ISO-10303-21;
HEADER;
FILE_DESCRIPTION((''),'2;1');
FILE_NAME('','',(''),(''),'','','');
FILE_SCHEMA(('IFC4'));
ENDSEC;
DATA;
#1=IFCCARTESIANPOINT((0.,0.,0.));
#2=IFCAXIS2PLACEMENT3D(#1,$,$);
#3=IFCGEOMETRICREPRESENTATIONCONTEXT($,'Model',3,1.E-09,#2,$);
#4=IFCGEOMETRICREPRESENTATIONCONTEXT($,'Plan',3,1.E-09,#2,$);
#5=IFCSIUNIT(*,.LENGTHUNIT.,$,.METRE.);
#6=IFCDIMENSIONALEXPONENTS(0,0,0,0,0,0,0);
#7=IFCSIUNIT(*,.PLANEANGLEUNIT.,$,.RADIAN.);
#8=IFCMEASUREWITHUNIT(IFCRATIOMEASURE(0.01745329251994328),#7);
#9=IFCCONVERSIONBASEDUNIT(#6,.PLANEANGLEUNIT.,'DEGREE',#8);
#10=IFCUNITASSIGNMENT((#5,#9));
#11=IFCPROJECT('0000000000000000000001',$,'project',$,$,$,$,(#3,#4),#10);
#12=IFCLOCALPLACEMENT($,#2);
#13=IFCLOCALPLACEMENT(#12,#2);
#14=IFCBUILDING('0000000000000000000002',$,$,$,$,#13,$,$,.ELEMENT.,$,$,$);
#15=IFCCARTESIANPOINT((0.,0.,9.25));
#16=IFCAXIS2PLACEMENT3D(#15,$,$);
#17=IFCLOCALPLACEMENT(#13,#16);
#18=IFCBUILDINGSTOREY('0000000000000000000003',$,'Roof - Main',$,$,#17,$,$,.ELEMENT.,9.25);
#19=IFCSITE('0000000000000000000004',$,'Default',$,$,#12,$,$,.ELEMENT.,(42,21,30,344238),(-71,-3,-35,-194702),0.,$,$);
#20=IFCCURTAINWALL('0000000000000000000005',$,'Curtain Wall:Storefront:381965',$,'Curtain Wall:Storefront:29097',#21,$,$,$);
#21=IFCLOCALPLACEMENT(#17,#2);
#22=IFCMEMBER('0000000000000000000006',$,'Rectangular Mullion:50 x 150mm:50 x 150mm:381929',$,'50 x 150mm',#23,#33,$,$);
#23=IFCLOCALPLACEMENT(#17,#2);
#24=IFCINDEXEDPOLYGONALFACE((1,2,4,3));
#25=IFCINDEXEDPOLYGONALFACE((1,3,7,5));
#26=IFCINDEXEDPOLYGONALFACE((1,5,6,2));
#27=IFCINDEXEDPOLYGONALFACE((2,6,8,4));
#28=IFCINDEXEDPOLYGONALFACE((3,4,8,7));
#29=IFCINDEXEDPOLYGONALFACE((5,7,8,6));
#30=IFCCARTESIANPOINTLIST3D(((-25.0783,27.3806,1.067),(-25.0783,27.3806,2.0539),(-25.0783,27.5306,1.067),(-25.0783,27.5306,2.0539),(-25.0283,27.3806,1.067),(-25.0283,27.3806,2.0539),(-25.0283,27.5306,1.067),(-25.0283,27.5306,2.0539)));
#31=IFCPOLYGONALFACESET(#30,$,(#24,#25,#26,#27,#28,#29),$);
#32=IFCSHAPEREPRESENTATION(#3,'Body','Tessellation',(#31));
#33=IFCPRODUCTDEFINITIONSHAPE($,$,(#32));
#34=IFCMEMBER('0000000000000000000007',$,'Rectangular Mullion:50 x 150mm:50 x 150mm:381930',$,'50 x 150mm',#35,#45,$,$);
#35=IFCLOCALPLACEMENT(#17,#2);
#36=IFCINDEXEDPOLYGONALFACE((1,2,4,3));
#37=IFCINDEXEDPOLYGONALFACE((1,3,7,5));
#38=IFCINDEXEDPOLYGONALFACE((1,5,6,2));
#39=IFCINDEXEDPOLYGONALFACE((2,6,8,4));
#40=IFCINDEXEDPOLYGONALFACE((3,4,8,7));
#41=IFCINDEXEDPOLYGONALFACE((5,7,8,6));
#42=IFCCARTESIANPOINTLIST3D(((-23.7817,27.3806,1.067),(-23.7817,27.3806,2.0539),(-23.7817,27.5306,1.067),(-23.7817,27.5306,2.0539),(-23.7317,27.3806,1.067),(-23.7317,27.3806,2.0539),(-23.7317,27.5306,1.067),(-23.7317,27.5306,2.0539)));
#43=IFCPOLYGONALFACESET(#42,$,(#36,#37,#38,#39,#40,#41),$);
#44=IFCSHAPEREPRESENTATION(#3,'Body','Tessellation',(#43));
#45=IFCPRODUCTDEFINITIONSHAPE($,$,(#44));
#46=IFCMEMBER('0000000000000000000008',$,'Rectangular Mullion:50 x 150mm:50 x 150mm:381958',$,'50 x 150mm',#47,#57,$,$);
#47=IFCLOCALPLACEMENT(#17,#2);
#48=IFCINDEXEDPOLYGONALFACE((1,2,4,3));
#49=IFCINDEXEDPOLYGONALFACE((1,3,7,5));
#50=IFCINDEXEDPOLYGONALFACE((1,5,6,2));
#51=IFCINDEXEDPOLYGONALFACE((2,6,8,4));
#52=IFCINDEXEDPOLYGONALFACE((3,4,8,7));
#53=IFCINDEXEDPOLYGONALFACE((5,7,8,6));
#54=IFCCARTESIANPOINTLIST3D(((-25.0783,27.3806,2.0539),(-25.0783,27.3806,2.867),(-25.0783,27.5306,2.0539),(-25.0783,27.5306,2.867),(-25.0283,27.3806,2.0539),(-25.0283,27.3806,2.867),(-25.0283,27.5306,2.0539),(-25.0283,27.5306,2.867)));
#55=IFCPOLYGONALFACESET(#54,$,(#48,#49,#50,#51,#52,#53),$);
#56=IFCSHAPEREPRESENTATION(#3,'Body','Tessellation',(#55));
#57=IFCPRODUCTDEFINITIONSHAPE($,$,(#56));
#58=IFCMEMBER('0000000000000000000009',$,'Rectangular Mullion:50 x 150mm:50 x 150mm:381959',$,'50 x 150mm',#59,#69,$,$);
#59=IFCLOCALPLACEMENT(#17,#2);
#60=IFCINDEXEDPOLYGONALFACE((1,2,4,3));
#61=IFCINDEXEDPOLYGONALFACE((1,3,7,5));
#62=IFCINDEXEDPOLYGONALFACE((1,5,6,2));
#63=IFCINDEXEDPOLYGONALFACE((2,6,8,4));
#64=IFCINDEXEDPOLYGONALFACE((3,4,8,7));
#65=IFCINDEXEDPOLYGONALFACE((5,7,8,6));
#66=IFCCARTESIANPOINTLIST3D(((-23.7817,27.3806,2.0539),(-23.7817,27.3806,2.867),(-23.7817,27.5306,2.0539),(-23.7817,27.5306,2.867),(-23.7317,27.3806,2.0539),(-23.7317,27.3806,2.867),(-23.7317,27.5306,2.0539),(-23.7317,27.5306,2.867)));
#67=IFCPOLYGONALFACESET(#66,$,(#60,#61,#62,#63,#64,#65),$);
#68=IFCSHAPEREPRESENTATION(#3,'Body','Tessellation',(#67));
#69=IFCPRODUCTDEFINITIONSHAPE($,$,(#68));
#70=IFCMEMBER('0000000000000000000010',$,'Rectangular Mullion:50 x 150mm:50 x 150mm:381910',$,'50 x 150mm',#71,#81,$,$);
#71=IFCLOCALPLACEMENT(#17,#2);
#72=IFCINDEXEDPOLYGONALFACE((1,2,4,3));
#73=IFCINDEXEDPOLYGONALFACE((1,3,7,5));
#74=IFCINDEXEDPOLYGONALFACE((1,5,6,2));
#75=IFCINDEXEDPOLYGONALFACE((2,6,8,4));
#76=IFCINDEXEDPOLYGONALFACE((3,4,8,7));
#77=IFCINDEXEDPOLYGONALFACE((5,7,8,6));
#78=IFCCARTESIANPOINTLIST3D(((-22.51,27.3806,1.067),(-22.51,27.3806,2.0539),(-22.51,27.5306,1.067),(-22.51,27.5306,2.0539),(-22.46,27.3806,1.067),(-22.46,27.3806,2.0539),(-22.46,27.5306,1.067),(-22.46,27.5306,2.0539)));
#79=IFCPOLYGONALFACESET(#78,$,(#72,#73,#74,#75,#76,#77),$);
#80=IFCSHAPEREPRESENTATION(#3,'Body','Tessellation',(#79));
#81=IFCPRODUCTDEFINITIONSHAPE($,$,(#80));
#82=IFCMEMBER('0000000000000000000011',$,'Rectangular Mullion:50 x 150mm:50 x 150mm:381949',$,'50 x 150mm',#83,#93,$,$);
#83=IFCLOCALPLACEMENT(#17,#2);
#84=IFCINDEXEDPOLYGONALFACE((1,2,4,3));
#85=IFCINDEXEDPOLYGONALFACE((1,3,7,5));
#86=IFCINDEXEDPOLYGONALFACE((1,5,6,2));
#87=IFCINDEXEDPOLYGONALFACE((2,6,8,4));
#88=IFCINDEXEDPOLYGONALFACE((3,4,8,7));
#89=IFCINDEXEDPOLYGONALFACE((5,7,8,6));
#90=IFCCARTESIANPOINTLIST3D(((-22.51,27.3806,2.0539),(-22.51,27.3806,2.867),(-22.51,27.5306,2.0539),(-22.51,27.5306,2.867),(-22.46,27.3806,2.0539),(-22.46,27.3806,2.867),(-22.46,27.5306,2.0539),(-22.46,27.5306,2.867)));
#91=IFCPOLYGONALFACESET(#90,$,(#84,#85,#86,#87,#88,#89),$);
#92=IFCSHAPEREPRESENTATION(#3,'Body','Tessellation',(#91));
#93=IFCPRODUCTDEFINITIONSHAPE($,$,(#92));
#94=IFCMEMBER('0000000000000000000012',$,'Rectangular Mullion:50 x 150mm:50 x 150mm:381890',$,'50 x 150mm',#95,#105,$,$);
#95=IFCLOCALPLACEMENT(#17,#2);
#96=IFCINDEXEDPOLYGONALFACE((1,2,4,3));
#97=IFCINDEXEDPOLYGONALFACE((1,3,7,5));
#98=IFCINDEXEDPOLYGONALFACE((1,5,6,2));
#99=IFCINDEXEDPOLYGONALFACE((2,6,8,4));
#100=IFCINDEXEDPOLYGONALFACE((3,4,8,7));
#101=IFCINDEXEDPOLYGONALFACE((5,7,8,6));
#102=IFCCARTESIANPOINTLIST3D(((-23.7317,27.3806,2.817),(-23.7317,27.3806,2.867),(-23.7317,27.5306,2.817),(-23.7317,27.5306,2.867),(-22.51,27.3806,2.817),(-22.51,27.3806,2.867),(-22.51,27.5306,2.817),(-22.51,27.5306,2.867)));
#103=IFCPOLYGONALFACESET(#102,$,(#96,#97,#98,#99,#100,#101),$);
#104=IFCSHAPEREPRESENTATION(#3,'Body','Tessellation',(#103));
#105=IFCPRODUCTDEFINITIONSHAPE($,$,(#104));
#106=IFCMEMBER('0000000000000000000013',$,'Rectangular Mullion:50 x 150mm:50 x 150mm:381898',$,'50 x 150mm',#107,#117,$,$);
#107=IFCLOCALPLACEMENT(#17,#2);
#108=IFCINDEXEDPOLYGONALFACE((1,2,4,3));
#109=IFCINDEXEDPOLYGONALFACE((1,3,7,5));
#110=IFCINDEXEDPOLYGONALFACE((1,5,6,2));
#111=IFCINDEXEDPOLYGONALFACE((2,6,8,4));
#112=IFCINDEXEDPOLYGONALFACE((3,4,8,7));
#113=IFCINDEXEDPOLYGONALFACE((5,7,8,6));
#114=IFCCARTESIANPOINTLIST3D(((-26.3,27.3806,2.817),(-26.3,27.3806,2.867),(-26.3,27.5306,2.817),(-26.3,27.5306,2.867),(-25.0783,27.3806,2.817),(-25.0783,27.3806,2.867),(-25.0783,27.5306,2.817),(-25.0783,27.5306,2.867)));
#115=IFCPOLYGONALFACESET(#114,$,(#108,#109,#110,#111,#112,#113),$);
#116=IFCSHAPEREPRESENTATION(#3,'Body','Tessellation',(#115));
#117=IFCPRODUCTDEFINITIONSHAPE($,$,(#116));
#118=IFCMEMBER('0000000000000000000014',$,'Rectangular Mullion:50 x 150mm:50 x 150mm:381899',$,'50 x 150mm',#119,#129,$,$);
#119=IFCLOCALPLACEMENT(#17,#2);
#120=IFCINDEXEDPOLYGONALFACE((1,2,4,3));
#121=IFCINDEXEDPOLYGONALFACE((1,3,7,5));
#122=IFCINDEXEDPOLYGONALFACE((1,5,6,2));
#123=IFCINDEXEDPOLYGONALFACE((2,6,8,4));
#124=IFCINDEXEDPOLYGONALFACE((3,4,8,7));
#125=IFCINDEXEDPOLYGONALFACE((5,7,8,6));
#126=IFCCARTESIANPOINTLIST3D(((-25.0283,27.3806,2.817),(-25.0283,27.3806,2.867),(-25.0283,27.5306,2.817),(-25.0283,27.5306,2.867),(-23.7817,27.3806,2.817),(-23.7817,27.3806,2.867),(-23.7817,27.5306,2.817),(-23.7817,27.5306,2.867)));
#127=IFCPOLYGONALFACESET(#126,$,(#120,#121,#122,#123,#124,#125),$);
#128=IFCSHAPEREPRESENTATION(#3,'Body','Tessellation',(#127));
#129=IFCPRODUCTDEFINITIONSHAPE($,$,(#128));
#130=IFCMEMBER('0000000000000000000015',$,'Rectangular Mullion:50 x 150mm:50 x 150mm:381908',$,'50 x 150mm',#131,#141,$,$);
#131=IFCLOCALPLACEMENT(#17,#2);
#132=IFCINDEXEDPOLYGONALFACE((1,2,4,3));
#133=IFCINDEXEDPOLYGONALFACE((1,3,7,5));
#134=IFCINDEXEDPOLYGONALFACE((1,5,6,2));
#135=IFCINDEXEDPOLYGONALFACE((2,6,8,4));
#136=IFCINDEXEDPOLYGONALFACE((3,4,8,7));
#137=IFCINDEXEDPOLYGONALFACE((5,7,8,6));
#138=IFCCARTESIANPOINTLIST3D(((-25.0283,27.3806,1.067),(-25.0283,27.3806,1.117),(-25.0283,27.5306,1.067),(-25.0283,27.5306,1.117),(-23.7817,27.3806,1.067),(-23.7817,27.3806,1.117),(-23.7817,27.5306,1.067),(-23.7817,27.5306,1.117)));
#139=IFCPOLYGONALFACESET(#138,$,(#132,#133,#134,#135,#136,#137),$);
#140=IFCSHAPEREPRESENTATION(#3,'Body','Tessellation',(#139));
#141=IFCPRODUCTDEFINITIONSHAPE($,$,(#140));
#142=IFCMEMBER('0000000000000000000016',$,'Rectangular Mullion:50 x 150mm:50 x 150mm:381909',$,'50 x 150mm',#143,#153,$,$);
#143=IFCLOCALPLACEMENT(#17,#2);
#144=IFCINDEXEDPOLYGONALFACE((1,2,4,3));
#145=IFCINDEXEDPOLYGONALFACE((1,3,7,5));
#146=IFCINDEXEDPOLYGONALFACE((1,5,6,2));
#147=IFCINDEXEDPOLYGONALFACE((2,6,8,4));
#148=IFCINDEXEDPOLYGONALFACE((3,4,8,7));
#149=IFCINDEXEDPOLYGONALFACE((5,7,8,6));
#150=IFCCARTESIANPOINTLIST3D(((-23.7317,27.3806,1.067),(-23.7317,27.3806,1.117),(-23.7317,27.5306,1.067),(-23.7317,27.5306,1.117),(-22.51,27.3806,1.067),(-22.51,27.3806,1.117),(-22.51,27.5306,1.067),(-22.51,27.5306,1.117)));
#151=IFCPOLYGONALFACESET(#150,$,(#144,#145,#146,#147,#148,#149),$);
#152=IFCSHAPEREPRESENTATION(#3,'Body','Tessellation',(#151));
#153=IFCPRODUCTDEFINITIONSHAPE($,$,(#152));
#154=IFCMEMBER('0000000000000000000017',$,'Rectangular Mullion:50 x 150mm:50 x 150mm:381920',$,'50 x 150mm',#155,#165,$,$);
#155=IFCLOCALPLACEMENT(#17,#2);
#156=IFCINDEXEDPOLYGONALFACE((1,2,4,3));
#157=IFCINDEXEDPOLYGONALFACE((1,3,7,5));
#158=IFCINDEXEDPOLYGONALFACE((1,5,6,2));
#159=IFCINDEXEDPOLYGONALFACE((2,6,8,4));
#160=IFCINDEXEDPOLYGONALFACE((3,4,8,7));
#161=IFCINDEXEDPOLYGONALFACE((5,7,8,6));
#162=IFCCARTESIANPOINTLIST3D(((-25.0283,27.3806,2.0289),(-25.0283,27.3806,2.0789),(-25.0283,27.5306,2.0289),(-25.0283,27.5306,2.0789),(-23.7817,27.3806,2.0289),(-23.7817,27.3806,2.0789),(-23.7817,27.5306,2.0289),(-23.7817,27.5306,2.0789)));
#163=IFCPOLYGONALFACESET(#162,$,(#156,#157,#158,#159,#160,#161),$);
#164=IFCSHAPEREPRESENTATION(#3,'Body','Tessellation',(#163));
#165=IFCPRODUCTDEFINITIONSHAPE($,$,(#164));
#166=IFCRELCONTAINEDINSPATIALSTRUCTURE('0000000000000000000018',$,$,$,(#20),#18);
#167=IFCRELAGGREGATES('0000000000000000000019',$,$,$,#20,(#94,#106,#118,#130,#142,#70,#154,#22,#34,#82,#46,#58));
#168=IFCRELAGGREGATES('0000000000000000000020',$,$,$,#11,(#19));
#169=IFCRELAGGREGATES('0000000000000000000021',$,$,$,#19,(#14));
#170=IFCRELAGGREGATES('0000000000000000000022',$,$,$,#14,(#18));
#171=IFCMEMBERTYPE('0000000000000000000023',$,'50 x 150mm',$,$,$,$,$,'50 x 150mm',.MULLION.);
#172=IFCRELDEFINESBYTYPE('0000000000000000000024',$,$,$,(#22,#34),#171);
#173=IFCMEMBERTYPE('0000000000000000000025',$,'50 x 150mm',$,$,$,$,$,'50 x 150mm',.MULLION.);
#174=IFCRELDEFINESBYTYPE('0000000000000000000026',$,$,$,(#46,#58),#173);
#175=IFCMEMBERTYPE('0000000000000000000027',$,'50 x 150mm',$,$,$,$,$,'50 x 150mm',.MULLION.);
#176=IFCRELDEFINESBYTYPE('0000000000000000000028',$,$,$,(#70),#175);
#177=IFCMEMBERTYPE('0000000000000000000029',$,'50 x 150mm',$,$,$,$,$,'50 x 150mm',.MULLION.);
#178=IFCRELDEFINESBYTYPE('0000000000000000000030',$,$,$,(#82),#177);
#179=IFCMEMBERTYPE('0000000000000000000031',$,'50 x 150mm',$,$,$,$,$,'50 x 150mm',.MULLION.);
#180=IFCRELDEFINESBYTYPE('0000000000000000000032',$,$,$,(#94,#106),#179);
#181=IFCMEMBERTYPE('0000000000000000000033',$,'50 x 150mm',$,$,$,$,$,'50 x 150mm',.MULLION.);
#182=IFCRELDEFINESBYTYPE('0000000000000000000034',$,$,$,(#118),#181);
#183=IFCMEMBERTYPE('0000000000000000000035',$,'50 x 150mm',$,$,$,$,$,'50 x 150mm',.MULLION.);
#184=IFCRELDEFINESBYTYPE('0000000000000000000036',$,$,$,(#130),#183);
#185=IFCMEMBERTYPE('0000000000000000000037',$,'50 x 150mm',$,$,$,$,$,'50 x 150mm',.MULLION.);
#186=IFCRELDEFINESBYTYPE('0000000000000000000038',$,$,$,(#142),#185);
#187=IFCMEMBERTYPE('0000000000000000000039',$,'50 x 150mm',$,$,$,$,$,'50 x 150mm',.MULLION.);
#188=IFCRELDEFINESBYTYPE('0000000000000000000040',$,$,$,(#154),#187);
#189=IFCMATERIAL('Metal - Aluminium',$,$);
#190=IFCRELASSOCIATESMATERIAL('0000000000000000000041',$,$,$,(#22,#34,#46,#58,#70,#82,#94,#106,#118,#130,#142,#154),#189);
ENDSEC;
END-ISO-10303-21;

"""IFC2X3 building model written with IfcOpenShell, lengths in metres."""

from ifc_helpers import new_model, entity, si_unit, converted_unit, frame, origin, origin_2d_with_axis, place, context, project, spatial, rectangle, extrude, source, transform, mapped, material, type_object, type_shapes, element, aggregate, save


model = new_model("IFC2X3")

# Units and contexts
model_context = context("Model", 3, precision=1e-09, world=origin())
plan_context = context("Plan", 3, precision=1e-09, world=origin())
ifc_project = project(units=[si_unit("LENGTHUNIT", "METRE"), converted_unit("PLANEANGLEUNIT", "DEGREE", entity("IfcRatioMeasure", 0.01745329251994328), si_unit("PLANEANGLEUNIT", "RADIAN"), dimensions=[0, 0, 0, 0, 0, 0, 0])], contexts=[model_context, plan_context])

# Site, building, storey
site_placement = place(None, origin())
site = spatial("IfcSite", under=ifc_project, at=site_placement, Name="Default", CompositionType="ELEMENT", RefLatitude=(42, 21, 30, 344238), RefLongitude=(-71, -3, -35, -194702), RefElevation=0.0)
building_placement = place(site_placement, origin())
building = spatial("IfcBuilding", under=site, at=building_placement, CompositionType="ELEMENT")
storey_placement = place(building_placement, frame((0.0, 0.0, 9.25)))
storey = spatial("IfcBuildingStorey", under=building, at=storey_placement, Name="Roof - Main", CompositionType="ELEMENT", Elevation=9.25)

# Shared definitions
ifc_material_1 = material(Name="Metal - Aluminium")

# Curtain wall, members
curtain_wall_1_placement = place(storey_placement, origin())
curtain_wall_1 = element("IfcCurtainWall", 1, at=curtain_wall_1_placement, inside=storey, Name="Curtain Wall:Storefront:381965", ObjectType="Curtain Wall:Storefront:29097")
member_type_1 = type_object("IfcMemberType", Name="50 x 150mm", ElementType="50 x 150mm", PredefinedType="MULLION")
shared_shape_1 = source(origin(), model_context, "Body", "SweptSolid", [
    extrude(rectangle(XDim=0.05, YDim=0.15, at=origin_2d_with_axis()), frame((0.0, 0.0, -0.9869), z_axis=(0.0, 0.0, 1.0), x_axis=(-1.0, 0.0, 0.0)), (0.0, 0.0, 1.0), 0.9869),
])
type_shapes(member_type_1, [shared_shape_1])
member_1_placement = place(storey_placement, frame((-25.0533, 27.4556, 1.067), z_axis=(0.0, 0.0, -1.0), x_axis=(1.0, 0.0, 0.0)))
member_1 = element("IfcMember", 2, at=member_1_placement, type_object=member_type_1, material=ifc_material_1, Name="Rectangular Mullion:50 x 150mm:50 x 150mm:381929", ObjectType="50 x 150mm", context=model_context, shape_type="MappedRepresentation", body=[
    mapped(shared_shape_1, transform((0.0, 0.0, 0.0), scale=1.0)),
])
member_2_placement = place(storey_placement, frame((-23.7567, 27.4556, 1.067), z_axis=(0.0, 0.0, -1.0), x_axis=(1.0, 0.0, 0.0)))
member_2 = element("IfcMember", 3, at=member_2_placement, type_object=member_type_1, material=ifc_material_1, Name="Rectangular Mullion:50 x 150mm:50 x 150mm:381930", ObjectType="50 x 150mm", context=model_context, shape_type="MappedRepresentation", body=[
    mapped(shared_shape_1, transform((0.0, 0.0, 0.0), scale=1.0)),
])
member_type_2 = type_object("IfcMemberType", Name="50 x 150mm", ElementType="50 x 150mm", PredefinedType="MULLION")
shared_shape_2 = source(origin(), model_context, "Body", "SweptSolid", [
    extrude(rectangle(XDim=0.05, YDim=0.15, at=origin_2d_with_axis()), frame((0.0, 0.0, -0.8131), z_axis=(0.0, 0.0, 1.0), x_axis=(-1.0, 0.0, 0.0)), (0.0, 0.0, 1.0), 0.8131),
])
type_shapes(member_type_2, [shared_shape_2])
member_3_placement = place(storey_placement, frame((-25.0533, 27.4556, 2.0539), z_axis=(0.0, 0.0, -1.0), x_axis=(1.0, 0.0, 0.0)))
member_3 = element("IfcMember", 4, at=member_3_placement, type_object=member_type_2, material=ifc_material_1, Name="Rectangular Mullion:50 x 150mm:50 x 150mm:381958", ObjectType="50 x 150mm", context=model_context, shape_type="MappedRepresentation", body=[
    mapped(shared_shape_2, transform((0.0, 0.0, 0.0), scale=1.0)),
])
member_4_placement = place(storey_placement, frame((-23.7567, 27.4556, 2.0539), z_axis=(0.0, 0.0, -1.0), x_axis=(1.0, 0.0, 0.0)))
member_4 = element("IfcMember", 5, at=member_4_placement, type_object=member_type_2, material=ifc_material_1, Name="Rectangular Mullion:50 x 150mm:50 x 150mm:381959", ObjectType="50 x 150mm", context=model_context, shape_type="MappedRepresentation", body=[
    mapped(shared_shape_2, transform((0.0, 0.0, 0.0), scale=1.0)),
])
member_type_3 = type_object("IfcMemberType", Name="50 x 150mm", ElementType="50 x 150mm", PredefinedType="MULLION")
shared_shape_3 = source(origin(), model_context, "Body", "SweptSolid", [
    extrude(rectangle(XDim=0.05, YDim=0.15, at=origin_2d_with_axis()), frame((-0.025, 0.0, -0.9869), z_axis=(0.0, 0.0, 1.0), x_axis=(-1.0, 0.0, 0.0)), (0.0, 0.0, 1.0), 0.9869),
])
type_shapes(member_type_3, [shared_shape_3])
member_5_placement = place(storey_placement, frame((-22.46, 27.4556, 1.067), z_axis=(0.0, 0.0, -1.0), x_axis=(1.0, 0.0, 0.0)))
member_5 = element("IfcMember", 6, at=member_5_placement, type_object=member_type_3, material=ifc_material_1, Name="Rectangular Mullion:50 x 150mm:50 x 150mm:381910", ObjectType="50 x 150mm", context=model_context, shape_type="MappedRepresentation", body=[
    mapped(shared_shape_3, transform((0.0, 0.0, 0.0), scale=1.0)),
])
member_type_4 = type_object("IfcMemberType", Name="50 x 150mm", ElementType="50 x 150mm", PredefinedType="MULLION")
shared_shape_4 = source(origin(), model_context, "Body", "SweptSolid", [
    extrude(rectangle(XDim=0.05, YDim=0.15, at=origin_2d_with_axis()), frame((-0.025, 0.0, -0.8131), z_axis=(0.0, 0.0, 1.0), x_axis=(-1.0, 0.0, 0.0)), (0.0, 0.0, 1.0), 0.8131),
])
type_shapes(member_type_4, [shared_shape_4])
member_6_placement = place(storey_placement, frame((-22.46, 27.4556, 2.0539), z_axis=(0.0, 0.0, -1.0), x_axis=(1.0, 0.0, 0.0)))
member_6 = element("IfcMember", 7, at=member_6_placement, type_object=member_type_4, material=ifc_material_1, Name="Rectangular Mullion:50 x 150mm:50 x 150mm:381949", ObjectType="50 x 150mm", context=model_context, shape_type="MappedRepresentation", body=[
    mapped(shared_shape_4, transform((0.0, 0.0, 0.0), scale=1.0)),
])
member_type_5 = type_object("IfcMemberType", Name="50 x 150mm", ElementType="50 x 150mm", PredefinedType="MULLION")
shared_shape_5 = source(origin(), model_context, "Body", "SweptSolid", [
    extrude(rectangle(XDim=0.05, YDim=0.15, at=origin_2d_with_axis()), frame((-0.025, 0.0, -1.2217), z_axis=(0.0, 0.0, 1.0), x_axis=(-1.0, 0.0, 0.0)), (0.0, 0.0, 1.0), 1.2217),
])
type_shapes(member_type_5, [shared_shape_5])
member_7_placement = place(storey_placement, frame((-22.51, 27.4556, 2.867), z_axis=(1.0, 0.0, 0.0), x_axis=(0.0, 0.0, 1.0)))
member_7 = element("IfcMember", 8, at=member_7_placement, type_object=member_type_5, material=ifc_material_1, Name="Rectangular Mullion:50 x 150mm:50 x 150mm:381890", ObjectType="50 x 150mm", context=model_context, shape_type="MappedRepresentation", body=[
    mapped(shared_shape_5, transform((0.0, 0.0, 0.0), scale=1.0)),
])
member_8_placement = place(storey_placement, frame((-25.0783, 27.4556, 2.867), z_axis=(1.0, 0.0, 0.0), x_axis=(0.0, 0.0, 1.0)))
member_8 = element("IfcMember", 9, at=member_8_placement, type_object=member_type_5, material=ifc_material_1, Name="Rectangular Mullion:50 x 150mm:50 x 150mm:381898", ObjectType="50 x 150mm", context=model_context, shape_type="MappedRepresentation", body=[
    mapped(shared_shape_5, transform((0.0, 0.0, 0.0), scale=1.0)),
])
member_type_6 = type_object("IfcMemberType", Name="50 x 150mm", ElementType="50 x 150mm", PredefinedType="MULLION")
shared_shape_6 = source(origin(), model_context, "Body", "SweptSolid", [
    extrude(rectangle(XDim=0.05, YDim=0.15, at=origin_2d_with_axis()), frame((-0.025, 0.0, -1.2467), z_axis=(0.0, 0.0, 1.0), x_axis=(-1.0, 0.0, 0.0)), (0.0, 0.0, 1.0), 1.2467),
])
type_shapes(member_type_6, [shared_shape_6])
member_9_placement = place(storey_placement, frame((-23.7817, 27.4556, 2.867), z_axis=(1.0, 0.0, 0.0), x_axis=(0.0, 0.0, 1.0)))
member_9 = element("IfcMember", 10, at=member_9_placement, type_object=member_type_6, material=ifc_material_1, Name="Rectangular Mullion:50 x 150mm:50 x 150mm:381899", ObjectType="50 x 150mm", context=model_context, shape_type="MappedRepresentation", body=[
    mapped(shared_shape_6, transform((0.0, 0.0, 0.0), scale=1.0)),
])
member_type_7 = type_object("IfcMemberType", Name="50 x 150mm", ElementType="50 x 150mm", PredefinedType="MULLION")
shared_shape_7 = source(origin(), model_context, "Body", "SweptSolid", [
    extrude(rectangle(XDim=0.05, YDim=0.15, at=origin_2d_with_axis()), frame((-0.025, 0.0, -1.2467), z_axis=(0.0, 0.0, 1.0), x_axis=(-1.0, 0.0, 0.0)), (0.0, 0.0, 1.0), 1.2467),
])
type_shapes(member_type_7, [shared_shape_7])
member_10_placement = place(storey_placement, frame((-25.0283, 27.4556, 1.067), z_axis=(-1.0, 0.0, 0.0), x_axis=(0.0, 0.0, -1.0)))
member_10 = element("IfcMember", 11, at=member_10_placement, type_object=member_type_7, material=ifc_material_1, Name="Rectangular Mullion:50 x 150mm:50 x 150mm:381908", ObjectType="50 x 150mm", context=model_context, shape_type="MappedRepresentation", body=[
    mapped(shared_shape_7, transform((0.0, 0.0, 0.0), scale=1.0)),
])
member_type_8 = type_object("IfcMemberType", Name="50 x 150mm", ElementType="50 x 150mm", PredefinedType="MULLION")
shared_shape_8 = source(origin(), model_context, "Body", "SweptSolid", [
    extrude(rectangle(XDim=0.05, YDim=0.15, at=origin_2d_with_axis()), frame((-0.025, 0.0, -1.2217), z_axis=(0.0, 0.0, 1.0), x_axis=(-1.0, 0.0, 0.0)), (0.0, 0.0, 1.0), 1.2217),
])
type_shapes(member_type_8, [shared_shape_8])
member_11_placement = place(storey_placement, frame((-23.7317, 27.4556, 1.067), z_axis=(-1.0, 0.0, 0.0), x_axis=(0.0, 0.0, -1.0)))
member_11 = element("IfcMember", 12, at=member_11_placement, type_object=member_type_8, material=ifc_material_1, Name="Rectangular Mullion:50 x 150mm:50 x 150mm:381909", ObjectType="50 x 150mm", context=model_context, shape_type="MappedRepresentation", body=[
    mapped(shared_shape_8, transform((0.0, 0.0, 0.0), scale=1.0)),
])
member_type_9 = type_object("IfcMemberType", Name="50 x 150mm", ElementType="50 x 150mm", PredefinedType="MULLION")
shared_shape_9 = source(origin(), model_context, "Body", "SweptSolid", [
    extrude(rectangle(XDim=0.05, YDim=0.15, at=origin_2d_with_axis()), frame((0.0, 0.0, -1.2467), z_axis=(0.0, 0.0, 1.0), x_axis=(-1.0, 0.0, 0.0)), (0.0, 0.0, 1.0), 1.2467),
])
type_shapes(member_type_9, [shared_shape_9])
member_12_placement = place(storey_placement, frame((-23.7817, 27.4556, 2.0539), z_axis=(1.0, 0.0, 0.0), x_axis=(0.0, 0.0, 1.0)))
member_12 = element("IfcMember", 13, at=member_12_placement, type_object=member_type_9, material=ifc_material_1, Name="Rectangular Mullion:50 x 150mm:50 x 150mm:381920", ObjectType="50 x 150mm", context=model_context, shape_type="MappedRepresentation", body=[
    mapped(shared_shape_9, transform((0.0, 0.0, 0.0), scale=1.0)),
])
aggregate(curtain_wall_1, [member_7, member_8, member_9, member_10, member_11, member_5, member_12, member_1, member_2, member_6, member_3, member_4])

save(model, "model.ifc")
